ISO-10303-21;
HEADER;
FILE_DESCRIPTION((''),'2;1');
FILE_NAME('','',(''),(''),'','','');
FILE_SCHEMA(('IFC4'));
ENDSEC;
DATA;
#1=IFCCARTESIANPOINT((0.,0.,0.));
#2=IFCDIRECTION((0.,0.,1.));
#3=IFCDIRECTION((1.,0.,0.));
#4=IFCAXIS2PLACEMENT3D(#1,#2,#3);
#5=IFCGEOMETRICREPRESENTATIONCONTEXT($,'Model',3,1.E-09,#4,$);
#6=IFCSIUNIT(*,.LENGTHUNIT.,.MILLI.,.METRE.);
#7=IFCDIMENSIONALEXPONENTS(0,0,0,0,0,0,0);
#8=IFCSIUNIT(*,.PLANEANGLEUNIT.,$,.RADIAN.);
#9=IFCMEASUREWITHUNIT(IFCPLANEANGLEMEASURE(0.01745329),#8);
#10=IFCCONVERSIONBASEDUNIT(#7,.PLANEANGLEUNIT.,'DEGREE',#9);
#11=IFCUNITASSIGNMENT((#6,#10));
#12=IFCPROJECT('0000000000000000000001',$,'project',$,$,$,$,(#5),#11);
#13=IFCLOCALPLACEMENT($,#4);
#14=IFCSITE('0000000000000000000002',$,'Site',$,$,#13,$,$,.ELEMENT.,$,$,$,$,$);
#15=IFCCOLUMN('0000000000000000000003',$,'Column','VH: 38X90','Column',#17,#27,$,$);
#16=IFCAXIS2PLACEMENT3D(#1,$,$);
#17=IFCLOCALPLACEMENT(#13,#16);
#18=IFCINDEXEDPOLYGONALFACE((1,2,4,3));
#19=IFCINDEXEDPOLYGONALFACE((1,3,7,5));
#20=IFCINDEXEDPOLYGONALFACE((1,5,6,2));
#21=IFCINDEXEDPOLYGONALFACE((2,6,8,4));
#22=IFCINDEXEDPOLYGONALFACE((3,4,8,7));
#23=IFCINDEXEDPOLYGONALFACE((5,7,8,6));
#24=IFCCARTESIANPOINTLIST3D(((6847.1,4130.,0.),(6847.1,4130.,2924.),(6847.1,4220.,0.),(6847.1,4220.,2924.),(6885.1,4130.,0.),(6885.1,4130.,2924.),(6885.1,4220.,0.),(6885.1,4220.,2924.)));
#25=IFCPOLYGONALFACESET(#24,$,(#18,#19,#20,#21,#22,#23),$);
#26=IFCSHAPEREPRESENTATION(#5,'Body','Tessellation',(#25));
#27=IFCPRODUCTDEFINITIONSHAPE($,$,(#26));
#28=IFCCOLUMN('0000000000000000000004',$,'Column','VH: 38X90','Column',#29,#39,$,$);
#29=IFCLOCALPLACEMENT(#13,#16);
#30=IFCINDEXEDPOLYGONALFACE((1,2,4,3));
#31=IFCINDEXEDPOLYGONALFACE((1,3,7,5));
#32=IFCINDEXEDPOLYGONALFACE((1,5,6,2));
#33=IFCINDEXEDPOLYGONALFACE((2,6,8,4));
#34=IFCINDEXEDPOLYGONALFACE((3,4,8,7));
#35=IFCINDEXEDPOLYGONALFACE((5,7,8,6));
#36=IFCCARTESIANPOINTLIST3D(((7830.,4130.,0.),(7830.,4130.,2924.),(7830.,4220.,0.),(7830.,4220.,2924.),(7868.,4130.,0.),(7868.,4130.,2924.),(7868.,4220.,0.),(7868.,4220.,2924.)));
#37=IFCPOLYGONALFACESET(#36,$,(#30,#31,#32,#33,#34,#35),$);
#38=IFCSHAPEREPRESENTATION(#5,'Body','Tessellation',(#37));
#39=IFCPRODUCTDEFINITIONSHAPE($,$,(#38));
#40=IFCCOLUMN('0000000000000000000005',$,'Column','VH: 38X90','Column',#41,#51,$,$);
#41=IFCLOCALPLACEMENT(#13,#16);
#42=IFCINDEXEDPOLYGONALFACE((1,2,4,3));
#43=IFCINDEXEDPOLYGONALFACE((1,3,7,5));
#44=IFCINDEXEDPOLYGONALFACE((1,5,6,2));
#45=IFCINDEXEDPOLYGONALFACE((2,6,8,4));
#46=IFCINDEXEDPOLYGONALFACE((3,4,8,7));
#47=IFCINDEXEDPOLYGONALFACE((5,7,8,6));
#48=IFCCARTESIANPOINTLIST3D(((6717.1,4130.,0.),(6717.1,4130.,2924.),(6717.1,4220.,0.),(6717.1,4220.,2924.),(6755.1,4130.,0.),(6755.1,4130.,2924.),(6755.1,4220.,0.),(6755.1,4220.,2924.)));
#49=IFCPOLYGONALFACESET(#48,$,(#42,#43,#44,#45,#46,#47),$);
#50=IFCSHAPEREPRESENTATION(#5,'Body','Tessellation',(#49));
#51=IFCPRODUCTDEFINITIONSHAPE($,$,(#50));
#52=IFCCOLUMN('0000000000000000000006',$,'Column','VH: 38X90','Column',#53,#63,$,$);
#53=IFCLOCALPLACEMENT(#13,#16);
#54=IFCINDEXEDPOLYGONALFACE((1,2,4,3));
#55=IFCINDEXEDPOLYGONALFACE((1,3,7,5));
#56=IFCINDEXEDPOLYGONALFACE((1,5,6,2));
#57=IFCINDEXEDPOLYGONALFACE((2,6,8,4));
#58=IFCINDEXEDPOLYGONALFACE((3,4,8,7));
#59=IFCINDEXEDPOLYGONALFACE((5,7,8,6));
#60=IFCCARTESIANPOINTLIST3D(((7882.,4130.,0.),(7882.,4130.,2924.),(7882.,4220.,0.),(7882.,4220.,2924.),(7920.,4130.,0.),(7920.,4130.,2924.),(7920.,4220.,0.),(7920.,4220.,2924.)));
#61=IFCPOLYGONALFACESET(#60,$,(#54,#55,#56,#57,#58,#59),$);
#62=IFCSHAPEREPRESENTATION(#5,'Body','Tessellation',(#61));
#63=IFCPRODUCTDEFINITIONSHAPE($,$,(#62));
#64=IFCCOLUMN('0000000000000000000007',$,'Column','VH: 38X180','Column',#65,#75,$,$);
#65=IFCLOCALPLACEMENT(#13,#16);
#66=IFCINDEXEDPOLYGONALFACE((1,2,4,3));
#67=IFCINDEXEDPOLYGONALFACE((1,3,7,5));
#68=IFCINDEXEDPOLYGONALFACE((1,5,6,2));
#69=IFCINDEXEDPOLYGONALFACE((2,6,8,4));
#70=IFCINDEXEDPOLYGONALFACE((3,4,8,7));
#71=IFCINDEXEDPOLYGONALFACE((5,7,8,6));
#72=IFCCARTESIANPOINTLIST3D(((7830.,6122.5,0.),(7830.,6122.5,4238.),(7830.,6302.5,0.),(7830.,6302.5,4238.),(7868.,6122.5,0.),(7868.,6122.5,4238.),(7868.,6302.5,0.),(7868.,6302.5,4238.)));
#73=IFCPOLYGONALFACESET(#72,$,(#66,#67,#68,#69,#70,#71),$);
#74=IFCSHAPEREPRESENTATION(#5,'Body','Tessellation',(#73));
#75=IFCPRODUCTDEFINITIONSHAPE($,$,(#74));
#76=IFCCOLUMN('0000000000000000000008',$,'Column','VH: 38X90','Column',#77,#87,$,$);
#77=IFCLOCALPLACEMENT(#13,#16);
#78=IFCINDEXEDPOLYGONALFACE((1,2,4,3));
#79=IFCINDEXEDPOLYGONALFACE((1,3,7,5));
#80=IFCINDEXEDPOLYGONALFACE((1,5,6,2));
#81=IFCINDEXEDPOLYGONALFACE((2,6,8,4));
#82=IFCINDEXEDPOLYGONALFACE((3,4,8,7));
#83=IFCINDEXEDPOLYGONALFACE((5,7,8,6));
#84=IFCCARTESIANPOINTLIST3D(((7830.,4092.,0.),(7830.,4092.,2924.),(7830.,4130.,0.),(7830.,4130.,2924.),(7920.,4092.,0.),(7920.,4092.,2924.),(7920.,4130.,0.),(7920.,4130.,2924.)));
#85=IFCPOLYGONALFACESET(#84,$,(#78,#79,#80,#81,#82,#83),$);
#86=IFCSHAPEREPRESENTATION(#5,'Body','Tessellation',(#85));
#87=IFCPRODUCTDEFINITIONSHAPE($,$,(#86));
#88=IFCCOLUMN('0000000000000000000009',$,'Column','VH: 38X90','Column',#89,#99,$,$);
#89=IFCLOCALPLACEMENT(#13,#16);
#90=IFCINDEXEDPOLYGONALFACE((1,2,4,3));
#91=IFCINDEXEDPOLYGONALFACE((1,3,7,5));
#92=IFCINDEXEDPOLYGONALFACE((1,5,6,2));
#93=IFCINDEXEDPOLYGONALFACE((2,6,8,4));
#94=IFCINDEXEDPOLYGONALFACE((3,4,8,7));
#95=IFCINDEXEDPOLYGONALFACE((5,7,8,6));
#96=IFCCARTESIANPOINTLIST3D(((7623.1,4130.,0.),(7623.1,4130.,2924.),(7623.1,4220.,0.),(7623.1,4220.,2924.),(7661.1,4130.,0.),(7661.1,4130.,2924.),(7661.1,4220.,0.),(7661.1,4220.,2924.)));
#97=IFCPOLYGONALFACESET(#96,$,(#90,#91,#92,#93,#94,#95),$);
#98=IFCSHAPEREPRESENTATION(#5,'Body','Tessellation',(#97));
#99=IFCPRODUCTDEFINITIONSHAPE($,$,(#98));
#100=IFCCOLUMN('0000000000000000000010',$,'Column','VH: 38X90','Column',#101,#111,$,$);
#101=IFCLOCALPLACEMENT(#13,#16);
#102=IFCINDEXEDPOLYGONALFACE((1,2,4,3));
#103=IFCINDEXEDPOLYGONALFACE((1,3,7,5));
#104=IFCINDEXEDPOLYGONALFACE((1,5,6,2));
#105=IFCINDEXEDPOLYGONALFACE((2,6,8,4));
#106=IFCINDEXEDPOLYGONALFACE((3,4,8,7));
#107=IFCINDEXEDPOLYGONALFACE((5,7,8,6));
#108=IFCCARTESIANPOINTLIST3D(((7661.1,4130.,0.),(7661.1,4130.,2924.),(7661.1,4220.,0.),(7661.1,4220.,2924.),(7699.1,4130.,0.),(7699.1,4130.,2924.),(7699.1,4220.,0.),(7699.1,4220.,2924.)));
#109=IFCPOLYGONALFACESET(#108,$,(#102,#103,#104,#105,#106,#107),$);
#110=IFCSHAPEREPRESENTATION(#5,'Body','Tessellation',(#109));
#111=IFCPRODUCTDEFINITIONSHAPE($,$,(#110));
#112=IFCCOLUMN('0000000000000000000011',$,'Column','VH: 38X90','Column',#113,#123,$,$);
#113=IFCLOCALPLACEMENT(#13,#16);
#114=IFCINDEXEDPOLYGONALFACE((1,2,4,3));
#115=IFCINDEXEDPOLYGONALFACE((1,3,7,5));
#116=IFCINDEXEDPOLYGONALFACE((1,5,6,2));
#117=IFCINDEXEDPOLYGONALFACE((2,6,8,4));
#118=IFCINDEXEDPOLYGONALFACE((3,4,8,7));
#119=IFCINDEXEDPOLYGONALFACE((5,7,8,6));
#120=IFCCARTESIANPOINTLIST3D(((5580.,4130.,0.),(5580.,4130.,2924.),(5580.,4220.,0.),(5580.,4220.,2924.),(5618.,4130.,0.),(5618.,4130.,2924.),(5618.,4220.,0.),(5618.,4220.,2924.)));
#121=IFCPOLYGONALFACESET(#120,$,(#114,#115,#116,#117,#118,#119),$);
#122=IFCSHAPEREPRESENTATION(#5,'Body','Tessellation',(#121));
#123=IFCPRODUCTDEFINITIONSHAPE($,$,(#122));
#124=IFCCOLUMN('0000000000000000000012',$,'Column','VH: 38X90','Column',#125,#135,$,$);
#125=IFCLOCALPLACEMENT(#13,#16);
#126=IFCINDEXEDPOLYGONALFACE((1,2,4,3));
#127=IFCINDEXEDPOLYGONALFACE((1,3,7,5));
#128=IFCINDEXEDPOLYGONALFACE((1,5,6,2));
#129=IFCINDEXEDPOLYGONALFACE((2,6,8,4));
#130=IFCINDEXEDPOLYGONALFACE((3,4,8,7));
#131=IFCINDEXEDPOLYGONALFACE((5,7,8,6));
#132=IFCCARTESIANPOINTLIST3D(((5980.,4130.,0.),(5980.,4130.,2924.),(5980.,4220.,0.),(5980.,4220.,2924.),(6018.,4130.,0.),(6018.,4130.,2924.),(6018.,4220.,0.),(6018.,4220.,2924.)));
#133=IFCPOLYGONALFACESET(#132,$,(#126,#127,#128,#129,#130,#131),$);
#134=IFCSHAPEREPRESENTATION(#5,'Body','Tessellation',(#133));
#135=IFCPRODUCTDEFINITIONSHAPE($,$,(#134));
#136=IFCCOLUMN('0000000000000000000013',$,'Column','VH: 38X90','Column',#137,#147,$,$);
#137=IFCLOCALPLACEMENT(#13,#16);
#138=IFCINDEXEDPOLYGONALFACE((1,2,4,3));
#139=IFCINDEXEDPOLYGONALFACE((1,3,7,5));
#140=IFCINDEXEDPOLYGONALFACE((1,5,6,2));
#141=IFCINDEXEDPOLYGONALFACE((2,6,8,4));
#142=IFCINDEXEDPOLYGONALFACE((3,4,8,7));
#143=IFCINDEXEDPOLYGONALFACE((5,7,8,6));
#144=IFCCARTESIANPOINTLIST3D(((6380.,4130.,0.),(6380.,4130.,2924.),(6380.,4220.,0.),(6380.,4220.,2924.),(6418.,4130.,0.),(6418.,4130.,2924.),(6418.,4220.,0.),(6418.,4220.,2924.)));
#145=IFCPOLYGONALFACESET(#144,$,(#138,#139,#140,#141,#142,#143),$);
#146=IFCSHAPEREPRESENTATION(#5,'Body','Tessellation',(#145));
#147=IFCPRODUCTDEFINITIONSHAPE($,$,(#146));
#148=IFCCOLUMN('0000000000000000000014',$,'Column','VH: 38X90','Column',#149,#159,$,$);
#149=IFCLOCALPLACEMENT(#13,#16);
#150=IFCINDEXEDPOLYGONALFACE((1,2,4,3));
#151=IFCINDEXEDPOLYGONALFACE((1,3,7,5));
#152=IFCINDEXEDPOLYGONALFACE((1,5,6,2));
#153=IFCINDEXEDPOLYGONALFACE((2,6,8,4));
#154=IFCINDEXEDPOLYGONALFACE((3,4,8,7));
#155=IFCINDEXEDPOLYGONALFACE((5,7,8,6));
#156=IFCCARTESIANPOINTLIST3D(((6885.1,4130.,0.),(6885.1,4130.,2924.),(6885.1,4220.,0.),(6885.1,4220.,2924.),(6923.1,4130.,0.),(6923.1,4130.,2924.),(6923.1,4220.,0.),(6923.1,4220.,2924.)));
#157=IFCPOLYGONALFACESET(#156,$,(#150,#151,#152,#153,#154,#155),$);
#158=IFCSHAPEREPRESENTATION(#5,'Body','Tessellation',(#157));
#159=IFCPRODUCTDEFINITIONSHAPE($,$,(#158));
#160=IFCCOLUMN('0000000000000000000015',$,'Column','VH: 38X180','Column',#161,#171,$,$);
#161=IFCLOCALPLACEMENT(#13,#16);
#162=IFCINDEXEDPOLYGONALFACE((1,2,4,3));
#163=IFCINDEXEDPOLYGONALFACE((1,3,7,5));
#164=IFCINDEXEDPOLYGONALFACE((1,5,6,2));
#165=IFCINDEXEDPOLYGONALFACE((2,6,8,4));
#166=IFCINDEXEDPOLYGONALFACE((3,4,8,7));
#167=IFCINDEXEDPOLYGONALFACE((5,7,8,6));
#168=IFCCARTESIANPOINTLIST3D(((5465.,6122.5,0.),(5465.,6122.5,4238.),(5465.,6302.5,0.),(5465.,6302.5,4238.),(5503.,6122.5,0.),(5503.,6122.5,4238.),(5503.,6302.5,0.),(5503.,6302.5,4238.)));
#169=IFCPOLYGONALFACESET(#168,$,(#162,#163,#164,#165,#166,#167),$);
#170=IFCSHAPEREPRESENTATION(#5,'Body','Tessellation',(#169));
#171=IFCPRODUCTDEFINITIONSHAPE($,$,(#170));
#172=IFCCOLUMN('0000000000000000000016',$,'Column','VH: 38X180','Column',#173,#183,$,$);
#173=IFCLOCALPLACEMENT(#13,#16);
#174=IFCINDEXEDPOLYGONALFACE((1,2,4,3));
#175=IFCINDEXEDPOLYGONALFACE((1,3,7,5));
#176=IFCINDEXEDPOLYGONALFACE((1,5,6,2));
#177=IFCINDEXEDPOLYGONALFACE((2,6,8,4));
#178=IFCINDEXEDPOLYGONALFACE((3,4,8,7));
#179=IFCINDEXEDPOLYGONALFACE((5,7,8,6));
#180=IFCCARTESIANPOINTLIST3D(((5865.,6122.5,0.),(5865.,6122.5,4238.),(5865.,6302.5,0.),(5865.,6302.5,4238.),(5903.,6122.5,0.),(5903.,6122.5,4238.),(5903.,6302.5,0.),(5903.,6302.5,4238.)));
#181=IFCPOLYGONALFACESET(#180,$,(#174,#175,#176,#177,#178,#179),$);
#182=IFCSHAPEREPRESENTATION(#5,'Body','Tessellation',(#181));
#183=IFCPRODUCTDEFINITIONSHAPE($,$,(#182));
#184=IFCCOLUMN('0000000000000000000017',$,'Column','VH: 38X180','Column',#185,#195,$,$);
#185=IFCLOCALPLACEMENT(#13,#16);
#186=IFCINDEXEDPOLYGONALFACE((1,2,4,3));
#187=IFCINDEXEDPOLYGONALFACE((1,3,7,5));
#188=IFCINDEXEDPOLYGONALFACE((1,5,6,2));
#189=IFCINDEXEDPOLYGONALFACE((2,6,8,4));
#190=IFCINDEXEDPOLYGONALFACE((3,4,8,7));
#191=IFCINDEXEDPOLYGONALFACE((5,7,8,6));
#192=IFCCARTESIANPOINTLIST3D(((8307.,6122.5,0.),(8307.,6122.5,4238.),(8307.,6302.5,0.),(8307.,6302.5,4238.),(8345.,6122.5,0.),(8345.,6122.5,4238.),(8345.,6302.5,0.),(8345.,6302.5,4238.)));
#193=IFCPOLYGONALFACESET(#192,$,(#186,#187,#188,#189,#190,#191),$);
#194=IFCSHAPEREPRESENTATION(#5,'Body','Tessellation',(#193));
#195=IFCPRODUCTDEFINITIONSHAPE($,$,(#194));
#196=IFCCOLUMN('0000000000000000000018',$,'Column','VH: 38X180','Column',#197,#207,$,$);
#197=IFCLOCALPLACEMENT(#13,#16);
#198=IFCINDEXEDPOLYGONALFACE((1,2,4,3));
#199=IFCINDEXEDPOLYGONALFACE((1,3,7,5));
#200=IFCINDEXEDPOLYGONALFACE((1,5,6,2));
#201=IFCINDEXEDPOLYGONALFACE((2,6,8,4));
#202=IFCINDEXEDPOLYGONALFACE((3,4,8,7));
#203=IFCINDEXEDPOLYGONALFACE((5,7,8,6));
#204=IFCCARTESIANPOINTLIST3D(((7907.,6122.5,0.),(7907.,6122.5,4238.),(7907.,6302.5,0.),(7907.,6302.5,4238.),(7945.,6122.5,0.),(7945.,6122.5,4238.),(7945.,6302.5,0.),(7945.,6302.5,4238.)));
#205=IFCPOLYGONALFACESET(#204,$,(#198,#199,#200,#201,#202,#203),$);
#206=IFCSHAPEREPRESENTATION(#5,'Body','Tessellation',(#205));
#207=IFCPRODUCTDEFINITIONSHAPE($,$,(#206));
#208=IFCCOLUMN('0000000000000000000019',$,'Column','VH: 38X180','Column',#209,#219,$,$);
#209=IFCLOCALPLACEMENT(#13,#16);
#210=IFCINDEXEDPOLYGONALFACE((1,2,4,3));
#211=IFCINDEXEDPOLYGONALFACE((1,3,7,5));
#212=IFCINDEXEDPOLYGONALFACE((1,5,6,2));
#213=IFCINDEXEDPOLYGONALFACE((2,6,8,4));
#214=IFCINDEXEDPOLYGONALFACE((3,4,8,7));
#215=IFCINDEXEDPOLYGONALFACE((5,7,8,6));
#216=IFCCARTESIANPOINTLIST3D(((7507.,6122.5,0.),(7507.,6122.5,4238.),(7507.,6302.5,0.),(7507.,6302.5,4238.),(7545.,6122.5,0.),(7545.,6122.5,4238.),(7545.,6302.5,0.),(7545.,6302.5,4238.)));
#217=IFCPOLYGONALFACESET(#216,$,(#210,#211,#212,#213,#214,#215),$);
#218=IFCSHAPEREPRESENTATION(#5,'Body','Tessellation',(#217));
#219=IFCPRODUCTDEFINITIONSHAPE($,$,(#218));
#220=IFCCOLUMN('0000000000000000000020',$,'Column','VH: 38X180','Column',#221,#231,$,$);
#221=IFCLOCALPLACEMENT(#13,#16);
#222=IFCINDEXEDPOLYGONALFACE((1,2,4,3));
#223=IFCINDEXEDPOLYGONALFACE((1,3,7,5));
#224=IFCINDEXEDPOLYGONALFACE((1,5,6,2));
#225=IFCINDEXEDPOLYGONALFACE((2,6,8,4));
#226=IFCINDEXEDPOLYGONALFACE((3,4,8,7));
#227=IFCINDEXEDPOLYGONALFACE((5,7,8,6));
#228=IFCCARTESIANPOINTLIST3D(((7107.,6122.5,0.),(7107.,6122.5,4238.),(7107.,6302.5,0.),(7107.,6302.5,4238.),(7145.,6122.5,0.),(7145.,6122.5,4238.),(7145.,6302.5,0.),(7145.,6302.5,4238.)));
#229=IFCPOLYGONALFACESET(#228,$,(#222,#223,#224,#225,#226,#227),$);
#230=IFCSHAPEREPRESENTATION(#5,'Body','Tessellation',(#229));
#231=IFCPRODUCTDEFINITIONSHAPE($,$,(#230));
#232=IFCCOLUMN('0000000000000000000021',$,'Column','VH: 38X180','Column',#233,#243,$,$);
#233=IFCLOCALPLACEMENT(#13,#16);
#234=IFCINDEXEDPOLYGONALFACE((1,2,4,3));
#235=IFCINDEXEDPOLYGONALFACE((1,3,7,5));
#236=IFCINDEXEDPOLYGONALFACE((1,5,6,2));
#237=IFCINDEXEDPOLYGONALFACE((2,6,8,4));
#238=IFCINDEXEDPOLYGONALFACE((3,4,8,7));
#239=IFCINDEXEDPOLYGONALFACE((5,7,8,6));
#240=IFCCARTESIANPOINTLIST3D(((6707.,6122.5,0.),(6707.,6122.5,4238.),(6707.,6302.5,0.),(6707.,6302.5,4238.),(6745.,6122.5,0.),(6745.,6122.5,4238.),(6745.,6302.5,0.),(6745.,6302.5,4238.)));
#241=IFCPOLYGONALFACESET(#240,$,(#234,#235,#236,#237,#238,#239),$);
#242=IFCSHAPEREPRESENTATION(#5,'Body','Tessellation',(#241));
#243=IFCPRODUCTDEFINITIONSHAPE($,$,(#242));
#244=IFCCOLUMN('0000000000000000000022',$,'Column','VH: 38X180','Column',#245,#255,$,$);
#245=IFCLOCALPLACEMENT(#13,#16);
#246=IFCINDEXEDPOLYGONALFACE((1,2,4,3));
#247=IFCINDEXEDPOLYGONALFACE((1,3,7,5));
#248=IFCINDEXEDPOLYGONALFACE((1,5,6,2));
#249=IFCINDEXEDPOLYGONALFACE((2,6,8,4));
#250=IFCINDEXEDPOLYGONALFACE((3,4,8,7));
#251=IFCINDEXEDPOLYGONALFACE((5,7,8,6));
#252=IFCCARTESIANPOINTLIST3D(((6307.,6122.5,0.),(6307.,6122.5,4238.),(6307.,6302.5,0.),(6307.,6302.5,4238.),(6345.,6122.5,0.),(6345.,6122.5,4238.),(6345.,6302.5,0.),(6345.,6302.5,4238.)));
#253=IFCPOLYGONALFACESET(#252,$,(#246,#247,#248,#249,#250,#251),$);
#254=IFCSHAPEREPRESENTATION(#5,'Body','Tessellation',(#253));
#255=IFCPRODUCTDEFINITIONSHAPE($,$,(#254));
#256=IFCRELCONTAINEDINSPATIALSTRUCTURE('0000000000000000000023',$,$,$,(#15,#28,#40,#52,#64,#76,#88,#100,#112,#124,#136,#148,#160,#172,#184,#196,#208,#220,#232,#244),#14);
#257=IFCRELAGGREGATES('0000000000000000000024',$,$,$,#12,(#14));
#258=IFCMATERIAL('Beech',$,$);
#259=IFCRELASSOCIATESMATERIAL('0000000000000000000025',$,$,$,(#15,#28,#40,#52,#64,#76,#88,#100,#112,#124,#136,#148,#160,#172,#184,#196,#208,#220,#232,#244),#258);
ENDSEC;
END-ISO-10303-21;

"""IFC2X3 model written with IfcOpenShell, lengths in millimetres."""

from ifc_helpers import new_model, entity, si_unit, converted_unit, frame, origin, origin_with_axes, origin_2d, place, context, project, spatial, rectangle, extrude, material, element, save


model = new_model("IFC2X3")

# Units and contexts
model_context = context("Model", 3, precision=1e-09, world=origin_with_axes())
ifc_project = project(units=[si_unit("LENGTHUNIT", "METRE", prefix="MILLI"), converted_unit("PLANEANGLEUNIT", "DEGREE", entity("IfcPlaneAngleMeasure", 0.01745329), si_unit("PLANEANGLEUNIT", "RADIAN"), dimensions=[0, 0, 0, 0, 0, 0, 0])], contexts=[model_context])

# Site
site_placement = place(None, origin_with_axes())
site = spatial("IfcSite", under=ifc_project, at=site_placement, Name="Site", CompositionType="ELEMENT")

# Columns
ifc_material = material(Name="Beech")
for number, where, z_axis, x_axis, name in (
    (1, (6866.1, 4175.0, 0.0), (0.0, 0.0, -1.0), (-1.0, 0.0, 0.0), "Column"),
    (2, (7849.0, 4175.0, 0.0), (0.0, 0.0, -1.0), (-1.0, 0.0, 0.0), "Column"),
    (3, (6736.1, 4175.0, 0.0), (0.0, 0.0, -1.0), (-1.0, 0.0, 0.0), "Column"),
    (4, (7901.0, 4175.0, 0.0), (0.0, 0.0, -1.0), (-1.0, 0.0, 0.0), "Column"),
):
    element("IfcColumn", number, at=place(None, frame(where, z_axis=z_axis, x_axis=x_axis)), inside=site, material=ifc_material, Name=name, Description="VH: 38X90", ObjectType="Column", context=model_context, shape_type="SweptSolid", body=[
        extrude(rectangle(XDim=38.0, YDim=90.0, at=origin_2d()), origin(), (0.0, 0.0, -1.0), 2924.0),
    ])
column_placement = place(None, frame((7849.0, 6212.5, 0.0), z_axis=(0.0, 0.0, -1.0), x_axis=(-1.0, 0.0, 0.0)))
element("IfcColumn", 5, at=column_placement, inside=site, material=ifc_material, Name="Column", Description="VH: 38X180", ObjectType="Column", context=model_context, shape_type="SweptSolid", body=[
    extrude(rectangle(XDim=38.0, YDim=180.0, at=origin_2d()), origin(), (0.0, 0.0, -1.0), 4238.0),
])
for number, where, z_axis, x_axis, name in (
    (6, (7875.0, 4111.0, 0.0), (0.0, 0.0, -1.0), (0.0, -1.0, 0.0), "Column"),
    (7, (7642.1, 4175.0, 0.0), (0.0, 0.0, -1.0), (-1.0, 0.0, 0.0), "Column"),
    (8, (7680.1, 4175.0, 0.0), (0.0, 0.0, -1.0), (-1.0, 0.0, 0.0), "Column"),
    (9, (5599.0, 4175.0, 0.0), (0.0, 0.0, -1.0), (-1.0, 0.0, 0.0), "Column"),
    (10, (5999.0, 4175.0, 0.0), (0.0, 0.0, -1.0), (-1.0, 0.0, 0.0), "Column"),
    (11, (6399.0, 4175.0, 0.0), (0.0, 0.0, -1.0), (-1.0, 0.0, 0.0), "Column"),
    (12, (6904.1, 4175.0, 0.0), (0.0, 0.0, -1.0), (-1.0, 0.0, 0.0), "Column"),
):
    element("IfcColumn", number, at=place(None, frame(where, z_axis=z_axis, x_axis=x_axis)), inside=site, material=ifc_material, Name=name, Description="VH: 38X90", ObjectType="Column", context=model_context, shape_type="SweptSolid", body=[
        extrude(rectangle(XDim=38.0, YDim=90.0, at=origin_2d()), origin(), (0.0, 0.0, -1.0), 2924.0),
    ])
for number, where, z_axis, x_axis, name in (
    (13, (5484.0, 6212.5, 0.0), (0.0, 0.0, -1.0), (-1.0, 0.0, 0.0), "Column"),
    (14, (5884.0, 6212.5, 0.0), (0.0, 0.0, -1.0), (-1.0, 0.0, 0.0), "Column"),
    (15, (8326.0, 6212.5, 0.0), (0.0, 0.0, -1.0), (-1.0, 0.0, 0.0), "Column"),
    (16, (7926.0, 6212.5, 0.0), (0.0, 0.0, -1.0), (-1.0, 0.0, 0.0), "Column"),
    (17, (7526.0, 6212.5, 0.0), (0.0, 0.0, -1.0), (-1.0, 0.0, 0.0), "Column"),
    (18, (7126.0, 6212.5, 0.0), (0.0, 0.0, -1.0), (-1.0, 0.0, 0.0), "Column"),
    (19, (6726.0, 6212.5, 0.0), (0.0, 0.0, -1.0), (-1.0, 0.0, 0.0), "Column"),
    (20, (6326.0, 6212.5, 0.0), (0.0, 0.0, -1.0), (-1.0, 0.0, 0.0), "Column"),
):
    element("IfcColumn", number, at=place(None, frame(where, z_axis=z_axis, x_axis=x_axis)), inside=site, material=ifc_material, Name=name, Description="VH: 38X180", ObjectType="Column", context=model_context, shape_type="SweptSolid", body=[
        extrude(rectangle(XDim=38.0, YDim=180.0, at=origin_2d()), origin(), (0.0, 0.0, -1.0), 4238.0),
    ])

save(model, "model.ifc")
